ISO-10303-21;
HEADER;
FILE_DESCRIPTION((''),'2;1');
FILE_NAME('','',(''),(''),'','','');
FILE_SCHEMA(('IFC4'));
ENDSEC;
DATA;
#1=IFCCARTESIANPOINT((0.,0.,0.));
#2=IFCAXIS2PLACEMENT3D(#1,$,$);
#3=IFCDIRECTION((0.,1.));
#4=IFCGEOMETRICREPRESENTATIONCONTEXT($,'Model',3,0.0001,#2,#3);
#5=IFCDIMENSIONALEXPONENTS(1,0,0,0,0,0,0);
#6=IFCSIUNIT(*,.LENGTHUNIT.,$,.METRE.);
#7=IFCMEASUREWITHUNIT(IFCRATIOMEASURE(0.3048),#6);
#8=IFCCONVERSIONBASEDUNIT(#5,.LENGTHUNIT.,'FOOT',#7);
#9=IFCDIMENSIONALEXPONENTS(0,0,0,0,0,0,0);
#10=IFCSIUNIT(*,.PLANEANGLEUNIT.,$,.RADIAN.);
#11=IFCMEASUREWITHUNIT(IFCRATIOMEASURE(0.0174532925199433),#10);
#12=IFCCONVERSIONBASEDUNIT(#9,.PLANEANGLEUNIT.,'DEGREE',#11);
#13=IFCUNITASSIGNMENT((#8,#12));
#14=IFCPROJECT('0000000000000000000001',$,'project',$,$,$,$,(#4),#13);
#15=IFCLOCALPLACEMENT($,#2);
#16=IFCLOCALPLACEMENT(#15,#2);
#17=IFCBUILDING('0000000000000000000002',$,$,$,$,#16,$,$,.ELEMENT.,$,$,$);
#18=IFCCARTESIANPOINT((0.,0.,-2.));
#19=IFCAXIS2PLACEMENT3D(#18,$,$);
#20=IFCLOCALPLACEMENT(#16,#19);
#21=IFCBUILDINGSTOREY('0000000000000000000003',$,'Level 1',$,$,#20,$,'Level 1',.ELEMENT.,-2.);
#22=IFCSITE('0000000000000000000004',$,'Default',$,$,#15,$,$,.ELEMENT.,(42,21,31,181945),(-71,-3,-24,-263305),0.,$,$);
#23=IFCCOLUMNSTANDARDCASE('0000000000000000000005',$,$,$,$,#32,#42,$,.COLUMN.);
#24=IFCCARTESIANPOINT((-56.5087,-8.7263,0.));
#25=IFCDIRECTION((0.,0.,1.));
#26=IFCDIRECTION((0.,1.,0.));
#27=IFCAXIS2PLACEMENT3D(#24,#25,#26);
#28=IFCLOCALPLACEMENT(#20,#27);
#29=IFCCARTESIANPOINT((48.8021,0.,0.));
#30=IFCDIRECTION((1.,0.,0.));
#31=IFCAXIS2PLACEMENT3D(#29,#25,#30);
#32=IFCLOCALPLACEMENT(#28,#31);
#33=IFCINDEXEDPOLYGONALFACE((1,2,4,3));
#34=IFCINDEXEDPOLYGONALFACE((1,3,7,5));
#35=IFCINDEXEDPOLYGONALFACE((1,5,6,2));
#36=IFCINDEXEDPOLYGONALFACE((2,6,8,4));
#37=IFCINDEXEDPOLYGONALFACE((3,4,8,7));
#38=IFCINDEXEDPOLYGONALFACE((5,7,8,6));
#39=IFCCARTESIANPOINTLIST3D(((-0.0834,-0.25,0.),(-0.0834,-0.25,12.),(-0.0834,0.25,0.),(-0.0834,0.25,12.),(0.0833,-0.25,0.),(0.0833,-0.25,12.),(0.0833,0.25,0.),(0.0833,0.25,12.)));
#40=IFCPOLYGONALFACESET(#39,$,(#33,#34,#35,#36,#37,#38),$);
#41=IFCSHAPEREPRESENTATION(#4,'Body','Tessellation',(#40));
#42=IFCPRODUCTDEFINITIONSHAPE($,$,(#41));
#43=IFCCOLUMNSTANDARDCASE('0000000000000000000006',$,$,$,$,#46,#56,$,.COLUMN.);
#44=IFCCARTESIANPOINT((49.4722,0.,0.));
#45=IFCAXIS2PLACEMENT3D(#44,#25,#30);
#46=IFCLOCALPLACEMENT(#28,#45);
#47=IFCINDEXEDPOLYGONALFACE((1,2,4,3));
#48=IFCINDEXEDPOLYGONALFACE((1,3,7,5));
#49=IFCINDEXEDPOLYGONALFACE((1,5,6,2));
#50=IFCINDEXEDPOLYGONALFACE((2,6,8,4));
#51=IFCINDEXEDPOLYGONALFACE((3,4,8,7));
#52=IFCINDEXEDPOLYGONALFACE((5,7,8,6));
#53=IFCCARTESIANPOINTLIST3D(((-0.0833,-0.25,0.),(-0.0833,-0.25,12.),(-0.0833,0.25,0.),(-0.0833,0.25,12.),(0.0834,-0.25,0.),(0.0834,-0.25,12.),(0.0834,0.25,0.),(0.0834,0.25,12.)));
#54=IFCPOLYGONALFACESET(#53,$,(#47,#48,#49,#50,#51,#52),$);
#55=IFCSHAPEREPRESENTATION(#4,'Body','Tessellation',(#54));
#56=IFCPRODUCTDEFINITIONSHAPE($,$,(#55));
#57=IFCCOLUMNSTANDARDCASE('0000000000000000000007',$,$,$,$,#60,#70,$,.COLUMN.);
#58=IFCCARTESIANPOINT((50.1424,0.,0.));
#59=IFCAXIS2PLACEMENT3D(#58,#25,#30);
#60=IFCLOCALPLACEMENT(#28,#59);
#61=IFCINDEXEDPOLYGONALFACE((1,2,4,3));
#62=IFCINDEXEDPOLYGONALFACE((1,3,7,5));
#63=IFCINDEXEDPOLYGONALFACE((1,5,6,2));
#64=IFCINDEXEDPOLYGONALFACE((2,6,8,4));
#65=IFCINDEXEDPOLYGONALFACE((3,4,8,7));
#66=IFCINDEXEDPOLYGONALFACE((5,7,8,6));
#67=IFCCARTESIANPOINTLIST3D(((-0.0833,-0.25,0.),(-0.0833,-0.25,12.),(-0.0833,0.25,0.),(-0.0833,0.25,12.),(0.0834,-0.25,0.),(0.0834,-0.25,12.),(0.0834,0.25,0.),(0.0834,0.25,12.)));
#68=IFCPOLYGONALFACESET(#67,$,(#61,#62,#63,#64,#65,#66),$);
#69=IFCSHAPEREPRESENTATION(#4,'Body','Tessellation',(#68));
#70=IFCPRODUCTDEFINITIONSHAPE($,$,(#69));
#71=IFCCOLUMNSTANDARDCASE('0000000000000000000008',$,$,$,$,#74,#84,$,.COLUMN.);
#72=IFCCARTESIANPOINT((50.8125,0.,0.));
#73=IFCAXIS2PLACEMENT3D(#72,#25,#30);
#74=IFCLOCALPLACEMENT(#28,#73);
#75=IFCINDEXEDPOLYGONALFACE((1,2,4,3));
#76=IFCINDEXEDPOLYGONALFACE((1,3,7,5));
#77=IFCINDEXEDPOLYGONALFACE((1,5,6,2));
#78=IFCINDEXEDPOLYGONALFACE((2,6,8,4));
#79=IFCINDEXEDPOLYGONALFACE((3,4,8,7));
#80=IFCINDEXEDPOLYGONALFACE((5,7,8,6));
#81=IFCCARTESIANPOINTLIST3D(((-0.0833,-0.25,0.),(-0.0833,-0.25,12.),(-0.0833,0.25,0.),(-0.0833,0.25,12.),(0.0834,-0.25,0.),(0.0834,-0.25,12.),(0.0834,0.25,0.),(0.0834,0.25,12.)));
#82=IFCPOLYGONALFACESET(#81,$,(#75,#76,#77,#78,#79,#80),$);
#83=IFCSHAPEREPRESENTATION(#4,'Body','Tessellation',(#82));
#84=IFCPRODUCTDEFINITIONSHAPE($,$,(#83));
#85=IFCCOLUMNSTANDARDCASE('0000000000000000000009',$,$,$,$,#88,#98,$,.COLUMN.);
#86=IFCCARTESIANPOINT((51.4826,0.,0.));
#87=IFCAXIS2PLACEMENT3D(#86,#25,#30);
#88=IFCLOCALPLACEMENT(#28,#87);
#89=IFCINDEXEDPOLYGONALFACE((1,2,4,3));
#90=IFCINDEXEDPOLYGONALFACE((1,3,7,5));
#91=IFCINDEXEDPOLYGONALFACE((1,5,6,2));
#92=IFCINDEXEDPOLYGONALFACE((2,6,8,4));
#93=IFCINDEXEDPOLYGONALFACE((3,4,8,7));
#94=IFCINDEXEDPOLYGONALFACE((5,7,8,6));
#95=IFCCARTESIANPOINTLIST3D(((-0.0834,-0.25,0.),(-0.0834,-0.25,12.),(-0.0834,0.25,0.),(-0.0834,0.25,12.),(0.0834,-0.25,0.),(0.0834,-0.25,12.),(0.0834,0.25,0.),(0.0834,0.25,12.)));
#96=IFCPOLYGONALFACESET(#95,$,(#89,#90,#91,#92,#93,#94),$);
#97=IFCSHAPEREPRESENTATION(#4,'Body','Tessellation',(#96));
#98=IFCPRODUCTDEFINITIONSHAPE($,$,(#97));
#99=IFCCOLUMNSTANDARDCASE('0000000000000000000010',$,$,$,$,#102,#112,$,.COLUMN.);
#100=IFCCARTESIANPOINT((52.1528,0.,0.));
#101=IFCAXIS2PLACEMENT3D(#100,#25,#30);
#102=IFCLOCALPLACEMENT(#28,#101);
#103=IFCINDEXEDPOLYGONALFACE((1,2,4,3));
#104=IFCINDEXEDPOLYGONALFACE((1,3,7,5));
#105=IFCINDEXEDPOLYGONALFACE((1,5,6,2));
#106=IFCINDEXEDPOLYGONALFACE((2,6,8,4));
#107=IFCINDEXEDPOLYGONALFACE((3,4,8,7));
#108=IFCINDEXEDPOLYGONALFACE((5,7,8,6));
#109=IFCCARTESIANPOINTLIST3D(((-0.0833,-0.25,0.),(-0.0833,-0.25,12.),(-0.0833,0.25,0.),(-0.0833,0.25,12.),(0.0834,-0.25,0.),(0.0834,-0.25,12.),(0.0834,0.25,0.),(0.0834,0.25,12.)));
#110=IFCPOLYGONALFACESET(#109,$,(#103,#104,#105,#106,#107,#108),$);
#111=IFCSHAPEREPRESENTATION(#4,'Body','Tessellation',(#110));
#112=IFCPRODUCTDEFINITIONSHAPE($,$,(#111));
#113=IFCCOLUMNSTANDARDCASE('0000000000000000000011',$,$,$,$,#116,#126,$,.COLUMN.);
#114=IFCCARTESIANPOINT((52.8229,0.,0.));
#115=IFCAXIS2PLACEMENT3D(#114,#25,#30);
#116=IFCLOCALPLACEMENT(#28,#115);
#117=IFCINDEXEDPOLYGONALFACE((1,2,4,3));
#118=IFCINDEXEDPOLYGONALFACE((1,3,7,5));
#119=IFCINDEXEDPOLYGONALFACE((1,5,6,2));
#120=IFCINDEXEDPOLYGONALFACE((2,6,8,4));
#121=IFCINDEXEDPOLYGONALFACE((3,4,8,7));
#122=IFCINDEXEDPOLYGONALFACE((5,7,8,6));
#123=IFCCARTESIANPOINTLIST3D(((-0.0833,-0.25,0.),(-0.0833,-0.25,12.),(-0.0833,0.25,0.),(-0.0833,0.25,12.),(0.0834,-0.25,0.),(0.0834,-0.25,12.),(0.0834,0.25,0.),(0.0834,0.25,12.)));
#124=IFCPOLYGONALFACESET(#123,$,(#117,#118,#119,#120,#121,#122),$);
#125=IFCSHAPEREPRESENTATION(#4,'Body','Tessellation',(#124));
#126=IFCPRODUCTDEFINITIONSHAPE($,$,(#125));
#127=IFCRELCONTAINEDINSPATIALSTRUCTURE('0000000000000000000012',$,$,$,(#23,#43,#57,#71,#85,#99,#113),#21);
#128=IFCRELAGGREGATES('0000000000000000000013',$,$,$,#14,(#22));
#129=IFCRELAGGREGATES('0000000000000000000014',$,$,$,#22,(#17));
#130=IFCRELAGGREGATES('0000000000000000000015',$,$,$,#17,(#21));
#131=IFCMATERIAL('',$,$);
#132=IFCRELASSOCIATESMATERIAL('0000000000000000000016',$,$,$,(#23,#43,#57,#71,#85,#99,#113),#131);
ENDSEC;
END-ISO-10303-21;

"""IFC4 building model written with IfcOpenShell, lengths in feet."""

from ifc_helpers import new_model, entity, si_unit, converted_unit, direction, frame, origin, place, context, project, spatial, rectangle, extrude, material, element, save


model = new_model("IFC4")

# Units and contexts
model_context = context("Model", 3, precision=0.0001, world=origin(), true_north=direction((0.0, 1.0)))
ifc_project = project(units=[converted_unit("LENGTHUNIT", "FOOT", entity("IfcRatioMeasure", 0.3048), si_unit("LENGTHUNIT", "METRE"), dimensions=[1, 0, 0, 0, 0, 0, 0]), converted_unit("PLANEANGLEUNIT", "DEGREE", entity("IfcRatioMeasure", 0.0174532925199433), si_unit("PLANEANGLEUNIT", "RADIAN"), dimensions=[0, 0, 0, 0, 0, 0, 0])], contexts=[model_context])

# Site, building, storey
site_placement = place(None, origin())
site = spatial("IfcSite", under=ifc_project, at=site_placement, Name="Default", CompositionType="ELEMENT", RefLatitude=(42, 21, 31, 181945), RefLongitude=(-71, -3, -24, -263305), RefElevation=0.0)
building_placement = place(site_placement, origin())
building = spatial("IfcBuilding", under=site, at=building_placement, CompositionType="ELEMENT")
storey_placement = place(building_placement, frame((0.0, 0.0, -2.0)))
storey = spatial("IfcBuildingStorey", under=building, at=storey_placement, Name="Level 1", LongName="Level 1", CompositionType="ELEMENT", Elevation=-2.0)

# Columns
ifc_material_1 = material(Name="")
placement_1 = place(storey_placement, frame((-56.5087, -8.7263, 0.0), z_axis=(0.0, 0.0, 1.0), x_axis=(0.0, 1.0, 0.0)))
for number, where, z_axis, x_axis in (
    (1, (48.8021, 0.0, 0.0), (0.0, 0.0, 1.0), (1.0, 0.0, 0.0)),
    (2, (49.4722, 0.0, 0.0), (0.0, 0.0, 1.0), (1.0, 0.0, 0.0)),
    (3, (50.1424, 0.0, 0.0), (0.0, 0.0, 1.0), (1.0, 0.0, 0.0)),
    (4, (50.8125, 0.0, 0.0), (0.0, 0.0, 1.0), (1.0, 0.0, 0.0)),
    (5, (51.4826, 0.0, 0.0), (0.0, 0.0, 1.0), (1.0, 0.0, 0.0)),
    (6, (52.1528, 0.0, 0.0), (0.0, 0.0, 1.0), (1.0, 0.0, 0.0)),
    (7, (52.8229, 0.0, 0.0), (0.0, 0.0, 1.0), (1.0, 0.0, 0.0)),
):
    element("IfcColumnStandardCase", number, at=place(placement_1, frame(where, z_axis=z_axis, x_axis=x_axis)), inside=storey, material=ifc_material_1, PredefinedType="COLUMN", context=model_context, shape_type="SweptSolid", body=[
        extrude(rectangle(XDim=0.1667, YDim=0.5), origin(), (0.0, 0.0, 1.0), 12.0),
    ])

save(model, "model.ifc")
